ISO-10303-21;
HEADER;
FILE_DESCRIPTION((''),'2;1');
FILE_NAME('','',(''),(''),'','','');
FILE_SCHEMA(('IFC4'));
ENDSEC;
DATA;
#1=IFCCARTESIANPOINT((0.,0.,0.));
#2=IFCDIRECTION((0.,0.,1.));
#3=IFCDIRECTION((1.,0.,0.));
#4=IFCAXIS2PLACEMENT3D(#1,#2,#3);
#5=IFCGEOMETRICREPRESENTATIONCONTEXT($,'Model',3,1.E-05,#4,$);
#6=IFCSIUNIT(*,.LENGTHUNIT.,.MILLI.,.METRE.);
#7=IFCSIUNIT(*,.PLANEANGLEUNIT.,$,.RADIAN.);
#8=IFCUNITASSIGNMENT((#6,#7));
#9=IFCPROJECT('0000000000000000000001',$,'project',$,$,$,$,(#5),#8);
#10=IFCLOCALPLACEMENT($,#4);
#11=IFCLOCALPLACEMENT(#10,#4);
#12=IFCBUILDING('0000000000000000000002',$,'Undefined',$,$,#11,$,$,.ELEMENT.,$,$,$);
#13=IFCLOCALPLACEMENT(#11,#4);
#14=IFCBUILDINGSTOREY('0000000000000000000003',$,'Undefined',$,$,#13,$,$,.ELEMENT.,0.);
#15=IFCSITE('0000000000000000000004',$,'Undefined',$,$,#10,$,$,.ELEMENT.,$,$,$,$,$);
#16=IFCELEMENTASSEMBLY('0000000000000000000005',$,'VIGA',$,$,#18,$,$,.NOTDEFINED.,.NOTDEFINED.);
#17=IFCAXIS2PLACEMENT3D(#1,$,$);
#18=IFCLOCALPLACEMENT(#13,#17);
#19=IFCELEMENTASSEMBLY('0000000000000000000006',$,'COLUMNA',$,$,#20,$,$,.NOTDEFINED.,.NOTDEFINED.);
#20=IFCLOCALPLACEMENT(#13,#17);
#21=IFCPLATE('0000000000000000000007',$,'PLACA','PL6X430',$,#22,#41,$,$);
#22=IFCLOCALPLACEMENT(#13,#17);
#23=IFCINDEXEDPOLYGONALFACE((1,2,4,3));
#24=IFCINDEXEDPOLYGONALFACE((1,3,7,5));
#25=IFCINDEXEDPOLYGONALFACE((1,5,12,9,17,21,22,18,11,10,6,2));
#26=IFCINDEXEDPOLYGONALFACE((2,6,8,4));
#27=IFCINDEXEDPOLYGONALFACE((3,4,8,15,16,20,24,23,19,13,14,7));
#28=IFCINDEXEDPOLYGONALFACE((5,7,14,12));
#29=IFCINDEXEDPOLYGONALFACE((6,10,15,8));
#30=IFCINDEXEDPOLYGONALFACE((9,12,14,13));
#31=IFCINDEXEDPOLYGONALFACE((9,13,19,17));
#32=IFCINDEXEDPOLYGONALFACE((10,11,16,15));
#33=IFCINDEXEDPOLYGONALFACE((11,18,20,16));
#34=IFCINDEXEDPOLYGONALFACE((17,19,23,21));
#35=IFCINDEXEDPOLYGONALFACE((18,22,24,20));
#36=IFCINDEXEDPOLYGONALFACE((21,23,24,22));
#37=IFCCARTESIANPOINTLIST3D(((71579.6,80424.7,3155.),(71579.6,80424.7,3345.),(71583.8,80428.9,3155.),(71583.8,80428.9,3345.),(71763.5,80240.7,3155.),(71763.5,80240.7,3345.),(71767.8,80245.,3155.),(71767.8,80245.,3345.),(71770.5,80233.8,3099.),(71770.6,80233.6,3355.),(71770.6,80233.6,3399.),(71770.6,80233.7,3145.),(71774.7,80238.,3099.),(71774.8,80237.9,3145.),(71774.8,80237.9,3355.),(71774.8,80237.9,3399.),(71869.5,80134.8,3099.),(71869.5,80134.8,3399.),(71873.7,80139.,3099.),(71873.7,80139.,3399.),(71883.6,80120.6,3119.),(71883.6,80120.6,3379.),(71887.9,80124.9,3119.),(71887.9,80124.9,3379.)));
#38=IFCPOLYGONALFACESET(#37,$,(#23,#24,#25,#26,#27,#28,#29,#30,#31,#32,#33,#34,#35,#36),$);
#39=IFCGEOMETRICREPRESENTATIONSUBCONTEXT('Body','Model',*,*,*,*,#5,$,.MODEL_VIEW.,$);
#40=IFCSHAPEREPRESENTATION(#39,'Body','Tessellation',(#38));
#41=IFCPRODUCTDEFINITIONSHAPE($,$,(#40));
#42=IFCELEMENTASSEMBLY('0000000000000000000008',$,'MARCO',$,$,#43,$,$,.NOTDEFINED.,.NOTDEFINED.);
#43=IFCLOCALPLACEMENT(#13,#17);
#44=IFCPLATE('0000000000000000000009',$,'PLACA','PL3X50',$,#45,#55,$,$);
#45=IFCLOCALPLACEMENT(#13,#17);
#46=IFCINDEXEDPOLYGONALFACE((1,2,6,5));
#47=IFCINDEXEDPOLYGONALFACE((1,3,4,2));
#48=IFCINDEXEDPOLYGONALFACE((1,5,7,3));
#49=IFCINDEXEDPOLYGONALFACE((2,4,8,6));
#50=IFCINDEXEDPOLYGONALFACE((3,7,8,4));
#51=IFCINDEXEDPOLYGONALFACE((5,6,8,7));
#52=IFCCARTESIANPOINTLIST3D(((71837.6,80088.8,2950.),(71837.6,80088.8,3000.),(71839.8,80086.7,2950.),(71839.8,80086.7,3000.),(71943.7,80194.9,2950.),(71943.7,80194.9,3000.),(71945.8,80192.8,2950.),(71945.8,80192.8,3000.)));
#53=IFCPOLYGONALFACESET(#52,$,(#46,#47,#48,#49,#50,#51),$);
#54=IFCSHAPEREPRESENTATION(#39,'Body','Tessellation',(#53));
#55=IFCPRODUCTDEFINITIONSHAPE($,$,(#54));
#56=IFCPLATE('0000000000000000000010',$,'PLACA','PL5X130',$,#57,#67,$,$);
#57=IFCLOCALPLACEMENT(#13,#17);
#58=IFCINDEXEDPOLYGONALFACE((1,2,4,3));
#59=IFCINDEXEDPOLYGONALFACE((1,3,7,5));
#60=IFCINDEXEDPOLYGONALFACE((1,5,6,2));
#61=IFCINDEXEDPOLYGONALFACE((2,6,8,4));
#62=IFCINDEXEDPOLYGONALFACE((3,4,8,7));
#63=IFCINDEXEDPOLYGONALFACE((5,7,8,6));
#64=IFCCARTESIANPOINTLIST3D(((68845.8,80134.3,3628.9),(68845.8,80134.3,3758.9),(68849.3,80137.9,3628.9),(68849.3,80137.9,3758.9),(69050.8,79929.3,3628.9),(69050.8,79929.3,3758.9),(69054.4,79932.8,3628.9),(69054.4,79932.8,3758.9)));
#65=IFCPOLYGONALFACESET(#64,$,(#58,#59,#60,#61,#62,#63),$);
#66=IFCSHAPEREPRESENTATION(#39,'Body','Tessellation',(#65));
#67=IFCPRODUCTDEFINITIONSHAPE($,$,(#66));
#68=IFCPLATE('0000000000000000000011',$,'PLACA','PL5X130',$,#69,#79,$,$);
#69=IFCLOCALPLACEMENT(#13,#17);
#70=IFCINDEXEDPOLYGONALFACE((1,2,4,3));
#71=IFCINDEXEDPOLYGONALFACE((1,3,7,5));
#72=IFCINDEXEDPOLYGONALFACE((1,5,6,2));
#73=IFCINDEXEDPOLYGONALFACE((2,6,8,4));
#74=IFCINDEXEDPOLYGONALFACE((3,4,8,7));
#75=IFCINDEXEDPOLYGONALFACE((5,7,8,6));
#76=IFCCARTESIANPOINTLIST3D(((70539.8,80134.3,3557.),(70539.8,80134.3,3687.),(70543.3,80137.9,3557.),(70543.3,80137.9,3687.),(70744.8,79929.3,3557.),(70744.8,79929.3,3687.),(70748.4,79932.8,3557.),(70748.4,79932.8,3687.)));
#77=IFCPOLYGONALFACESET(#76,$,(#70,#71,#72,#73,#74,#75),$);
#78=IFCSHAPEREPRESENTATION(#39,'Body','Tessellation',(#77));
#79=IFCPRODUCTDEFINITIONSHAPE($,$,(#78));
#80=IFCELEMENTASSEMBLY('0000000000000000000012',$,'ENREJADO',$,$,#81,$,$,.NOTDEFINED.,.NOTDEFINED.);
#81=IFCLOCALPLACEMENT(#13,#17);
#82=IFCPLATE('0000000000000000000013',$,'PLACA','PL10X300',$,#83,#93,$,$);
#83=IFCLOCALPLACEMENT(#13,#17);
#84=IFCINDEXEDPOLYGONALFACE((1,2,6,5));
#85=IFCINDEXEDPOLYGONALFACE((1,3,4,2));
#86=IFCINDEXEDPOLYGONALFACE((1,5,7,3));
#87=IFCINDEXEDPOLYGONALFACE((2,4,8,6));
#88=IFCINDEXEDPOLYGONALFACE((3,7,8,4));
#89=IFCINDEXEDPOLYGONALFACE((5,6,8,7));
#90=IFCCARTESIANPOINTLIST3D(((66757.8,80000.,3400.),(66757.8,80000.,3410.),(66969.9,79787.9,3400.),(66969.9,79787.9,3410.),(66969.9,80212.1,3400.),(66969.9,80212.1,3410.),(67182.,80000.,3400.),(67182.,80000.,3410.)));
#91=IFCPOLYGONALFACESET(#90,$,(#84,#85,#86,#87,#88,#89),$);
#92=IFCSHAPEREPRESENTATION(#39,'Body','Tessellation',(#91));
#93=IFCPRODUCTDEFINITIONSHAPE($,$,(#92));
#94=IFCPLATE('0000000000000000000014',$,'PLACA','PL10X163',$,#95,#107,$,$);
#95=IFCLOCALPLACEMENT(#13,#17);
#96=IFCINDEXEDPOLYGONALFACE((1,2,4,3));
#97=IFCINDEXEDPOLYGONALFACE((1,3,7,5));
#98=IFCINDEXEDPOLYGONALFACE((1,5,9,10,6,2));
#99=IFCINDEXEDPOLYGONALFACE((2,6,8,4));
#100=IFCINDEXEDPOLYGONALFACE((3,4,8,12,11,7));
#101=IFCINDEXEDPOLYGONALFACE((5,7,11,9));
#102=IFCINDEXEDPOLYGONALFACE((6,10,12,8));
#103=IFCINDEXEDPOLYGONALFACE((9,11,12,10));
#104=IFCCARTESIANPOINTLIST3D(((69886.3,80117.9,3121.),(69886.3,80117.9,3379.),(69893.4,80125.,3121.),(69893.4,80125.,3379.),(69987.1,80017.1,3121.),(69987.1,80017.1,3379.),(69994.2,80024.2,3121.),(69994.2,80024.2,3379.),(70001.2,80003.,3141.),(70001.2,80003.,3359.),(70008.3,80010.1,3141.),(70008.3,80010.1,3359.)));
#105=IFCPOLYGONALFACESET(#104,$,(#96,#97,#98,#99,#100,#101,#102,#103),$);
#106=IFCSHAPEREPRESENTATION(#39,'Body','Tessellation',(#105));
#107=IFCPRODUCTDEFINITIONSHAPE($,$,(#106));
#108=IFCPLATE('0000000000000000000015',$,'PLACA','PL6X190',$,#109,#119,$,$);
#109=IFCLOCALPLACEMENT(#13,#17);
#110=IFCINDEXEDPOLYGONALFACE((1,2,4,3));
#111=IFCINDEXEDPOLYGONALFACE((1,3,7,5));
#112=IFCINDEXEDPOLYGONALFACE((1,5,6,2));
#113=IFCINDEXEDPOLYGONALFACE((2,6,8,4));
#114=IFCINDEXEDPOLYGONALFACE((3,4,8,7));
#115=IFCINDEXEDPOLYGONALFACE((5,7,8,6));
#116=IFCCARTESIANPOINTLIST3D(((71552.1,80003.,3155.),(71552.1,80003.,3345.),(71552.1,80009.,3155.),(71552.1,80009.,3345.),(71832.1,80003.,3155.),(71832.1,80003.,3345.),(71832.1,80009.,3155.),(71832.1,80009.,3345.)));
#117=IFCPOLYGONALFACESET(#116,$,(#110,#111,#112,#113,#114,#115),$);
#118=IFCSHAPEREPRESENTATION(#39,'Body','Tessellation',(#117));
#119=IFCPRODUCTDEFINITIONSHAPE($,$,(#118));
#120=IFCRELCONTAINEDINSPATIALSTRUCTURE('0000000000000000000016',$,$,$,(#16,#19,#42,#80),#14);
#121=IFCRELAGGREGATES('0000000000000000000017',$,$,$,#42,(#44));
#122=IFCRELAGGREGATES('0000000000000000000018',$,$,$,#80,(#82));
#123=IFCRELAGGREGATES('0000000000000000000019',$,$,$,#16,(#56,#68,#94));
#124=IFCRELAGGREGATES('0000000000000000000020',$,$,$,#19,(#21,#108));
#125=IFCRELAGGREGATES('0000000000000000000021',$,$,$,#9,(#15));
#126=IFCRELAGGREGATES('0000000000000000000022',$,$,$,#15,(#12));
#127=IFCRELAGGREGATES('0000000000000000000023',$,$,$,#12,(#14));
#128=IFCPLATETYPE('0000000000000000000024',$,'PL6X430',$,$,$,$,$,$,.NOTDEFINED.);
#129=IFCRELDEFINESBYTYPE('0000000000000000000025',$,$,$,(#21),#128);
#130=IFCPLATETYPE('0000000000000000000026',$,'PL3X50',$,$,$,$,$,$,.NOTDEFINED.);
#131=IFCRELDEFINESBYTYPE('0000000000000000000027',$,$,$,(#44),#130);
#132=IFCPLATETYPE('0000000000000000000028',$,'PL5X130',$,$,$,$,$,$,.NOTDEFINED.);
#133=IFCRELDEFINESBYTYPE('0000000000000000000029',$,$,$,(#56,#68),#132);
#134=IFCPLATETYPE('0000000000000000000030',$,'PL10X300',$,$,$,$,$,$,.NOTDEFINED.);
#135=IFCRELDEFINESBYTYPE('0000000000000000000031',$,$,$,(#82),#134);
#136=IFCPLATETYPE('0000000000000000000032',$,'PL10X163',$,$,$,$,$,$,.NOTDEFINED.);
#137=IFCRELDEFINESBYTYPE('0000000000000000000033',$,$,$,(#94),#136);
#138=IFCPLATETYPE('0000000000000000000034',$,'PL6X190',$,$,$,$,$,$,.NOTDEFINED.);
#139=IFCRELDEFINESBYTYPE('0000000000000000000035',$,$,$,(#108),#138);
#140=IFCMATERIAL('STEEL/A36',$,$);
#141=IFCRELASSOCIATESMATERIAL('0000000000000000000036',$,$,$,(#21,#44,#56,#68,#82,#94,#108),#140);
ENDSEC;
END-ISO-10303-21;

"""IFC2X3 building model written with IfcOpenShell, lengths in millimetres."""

from ifc_helpers import new_model, si_unit, frame, origin_with_axes, place, context, subcontext, project, spatial, polyline, outline, extrude, material, type_object, element, aggregate, save


model = new_model("IFC2X3")

# Units and contexts
model_context = context("Model", 3, precision=1e-05, world=origin_with_axes())
body_context = subcontext(model_context, "Body", "Model", "MODEL_VIEW")
ifc_project = project(units=[si_unit("LENGTHUNIT", "METRE", prefix="MILLI"), si_unit("PLANEANGLEUNIT", "RADIAN")], contexts=[model_context])

# Site, building, storey
site_placement = place(None, origin_with_axes())
site = spatial("IfcSite", under=ifc_project, at=site_placement, Name="Undefined", CompositionType="ELEMENT")
building_placement = place(site_placement, origin_with_axes())
building = spatial("IfcBuilding", under=site, at=building_placement, Name="Undefined", CompositionType="ELEMENT")
storey_placement = place(building_placement, origin_with_axes())
storey = spatial("IfcBuildingStorey", under=building, at=storey_placement, Name="Undefined", CompositionType="ELEMENT", Elevation=0.0)

# Element assembly
assembly_1_placement = place(storey_placement, origin_with_axes())
assembly_1 = element("IfcElementAssembly", 1, at=assembly_1_placement, inside=storey, Name="VIGA", AssemblyPlace="NOTDEFINED", PredefinedType="NOTDEFINED")
ifc_material_1 = material(Name="STEEL/A36")

# Element assemblies, plates
assembly_2_placement = place(storey_placement, origin_with_axes())
assembly_2 = element("IfcElementAssembly", 2, at=assembly_2_placement, inside=storey, Name="COLUMNA", AssemblyPlace="NOTDEFINED", PredefinedType="NOTDEFINED")
plate_type_1 = type_object("IfcPlateType", Name="PL6X430", PredefinedType="NOTDEFINED")
plate_1_placement = place(assembly_2_placement, frame((71885.8, 80122.7, 3099.0), z_axis=(0.7071, 0.707113, 0.0), x_axis=(-0.707113, 0.7071, 0.0)))
plate_1 = element("IfcPlate", 3, at=plate_1_placement, type_object=plate_type_1, material=ifc_material_1, Name="PLACA", Description="PL6X430", context=body_context, shape_type="SweptSolid", body=[
    extrude(outline(polyline([(0.0, 20.0), (20.0, 0.0), (160.0, 0.0), (159.9, 46.0), (169.8, 56.0), (430.0, 56.0), (430.0, 246.0), (169.8, 246.0), (159.8, 256.0), (159.8, 300.0), (20.0, 300.0), (0.0, 280.0), (0.0, 20.0)])), frame((0.0, 0.0, -3.0), z_axis=(0.0, 0.0, 1.0), x_axis=(1.0, 0.0, 0.0)), (0.0, 0.0, 1.0), 6.0),
])
assembly_3_placement = place(storey_placement, origin_with_axes())
assembly_3 = element("IfcElementAssembly", 4, at=assembly_3_placement, inside=storey, Name="MARCO", AssemblyPlace="NOTDEFINED", PredefinedType="NOTDEFINED")
plate_type_2 = type_object("IfcPlateType", Name="PL3X50", PredefinedType="NOTDEFINED")
plate_2_placement = place(assembly_3_placement, frame((71838.7, 80087.8, 2950.0), z_axis=(-0.707107, 0.707107, 0.0), x_axis=(0.0, 0.0, 1.0)))
plate_2 = element("IfcPlate", 5, at=plate_2_placement, type_object=plate_type_2, material=ifc_material_1, Name="PLACA", Description="PL3X50", context=body_context, shape_type="SweptSolid", body=[
    extrude(outline(polyline([(0.0, 0.0), (50.0, 0.0), (50.0, 150.0), (0.0, 150.0), (0.0, 0.0)])), frame((0.0, 0.0, -1.5), z_axis=(0.0, 0.0, 1.0), x_axis=(1.0, 0.0, 0.0)), (0.0, 0.0, 1.0), 3.0),
])
aggregate(assembly_3, [plate_2])

# Plates
plate_type_3 = type_object("IfcPlateType", Name="PL5X130", PredefinedType="NOTDEFINED")
plate_3_placement = place(assembly_1_placement, frame((69052.6, 79931.1, 3758.9), z_axis=(-0.707107, -0.707107, 0.000003), x_axis=(-0.707107, 0.707107, 0.0)))
plate_3 = element("IfcPlate", 6, at=plate_3_placement, type_object=plate_type_3, material=ifc_material_1, Name="PLACA", Description="PL5X130", context=body_context, shape_type="SweptSolid", body=[
    extrude(outline(polyline([(0.0, 0.0), (290.0, 0.0), (290.0, 130.0), (0.0, 130.0), (0.0, 0.0)])), frame((0.0, 0.0, -2.5), z_axis=(0.0, 0.0, 1.0), x_axis=(1.0, 0.0, 0.0)), (0.0, 0.0, 1.0), 5.0),
])
plate_4_placement = place(assembly_1_placement, frame((70746.6, 79931.1, 3687.0), z_axis=(-0.707107, -0.707107, -0.000001), x_axis=(-0.707107, 0.707107, 0.0)))
plate_4 = element("IfcPlate", 7, at=plate_4_placement, type_object=plate_type_3, material=ifc_material_1, Name="PLACA", Description="PL5X130", context=body_context, shape_type="SweptSolid", body=[
    extrude(outline(polyline([(0.0, 0.0), (290.0, 0.0), (290.0, 130.0), (0.0, 130.0), (0.0, 0.0)])), frame((0.0, 0.0, -2.5), z_axis=(0.0, 0.0, 1.0), x_axis=(1.0, 0.0, 0.0)), (0.0, 0.0, 1.0), 5.0),
])

# Element assembly, plate
assembly_4_placement = place(storey_placement, origin_with_axes())
assembly_4 = element("IfcElementAssembly", 8, at=assembly_4_placement, inside=storey, Name="ENREJADO", AssemblyPlace="NOTDEFINED", PredefinedType="NOTDEFINED")
plate_type_4 = type_object("IfcPlateType", Name="PL10X300", PredefinedType="NOTDEFINED")
plate_5_placement = place(assembly_4_placement, frame((67076.0, 80106.1, 3405.0), z_axis=(0.0, 0.0, 1.0), x_axis=(-0.707107, -0.707107, 0.0)))
plate_5 = element("IfcPlate", 9, at=plate_5_placement, type_object=plate_type_4, material=ifc_material_1, Name="PLACA", Description="PL10X300", context=body_context, shape_type="SweptSolid", body=[
    extrude(outline(polyline([(0.0, -150.0), (0.0, 150.0), (300.0, 150.0), (300.0, -150.0), (0.0, -150.0)])), frame((0.0, 0.0, -5.0), z_axis=(0.0, 0.0, 1.0), x_axis=(1.0, 0.0, 0.0)), (0.0, 0.0, 1.0), 10.0),
])
aggregate(assembly_4, [plate_5])

# Plates
plate_type_5 = type_object("IfcPlateType", Name="PL10X163", PredefinedType="NOTDEFINED")
plate_6_placement = place(assembly_1_placement, frame((70004.8, 80006.5, 3121.0), z_axis=(0.707107, 0.707107, 0.0), x_axis=(-0.707107, 0.707107, 0.0)))
plate_6 = element("IfcPlate", 10, at=plate_6_placement, type_object=plate_type_5, material=ifc_material_1, Name="PLACA", Description="PL10X163", context=body_context, shape_type="SweptSolid", body=[
    extrude(outline(polyline([(0.0, 20.0), (20.0, 0.0), (162.5, 0.0), (162.5, 258.0), (20.0, 258.0), (0.0, 238.0), (0.0, 20.0)])), frame((0.0, 0.0, -5.0), z_axis=(0.0, 0.0, 1.0), x_axis=(1.0, 0.0, 0.0)), (0.0, 0.0, 1.0), 10.0),
])
aggregate(assembly_1, [plate_3, plate_4, plate_6])
plate_type_6 = type_object("IfcPlateType", Name="PL6X190", PredefinedType="NOTDEFINED")
plate_7_placement = place(assembly_2_placement, frame((71552.1, 80006.0, 3250.0), z_axis=(0.0, -1.0, 0.0), x_axis=(1.0, 0.0, 0.0)))
plate_7 = element("IfcPlate", 11, at=plate_7_placement, type_object=plate_type_6, material=ifc_material_1, Name="PLACA", Description="PL6X190", context=body_context, shape_type="SweptSolid", body=[
    extrude(outline(polyline([(0.0, -95.0), (0.0, 95.0), (280.0, 95.0), (280.0, -95.0), (0.0, -95.0)])), frame((0.0, 0.0, -3.0), z_axis=(0.0, 0.0, 1.0), x_axis=(1.0, 0.0, 0.0)), (0.0, 0.0, 1.0), 6.0),
])

aggregate(assembly_2, [plate_1, plate_7])

save(model, "model.ifc")
